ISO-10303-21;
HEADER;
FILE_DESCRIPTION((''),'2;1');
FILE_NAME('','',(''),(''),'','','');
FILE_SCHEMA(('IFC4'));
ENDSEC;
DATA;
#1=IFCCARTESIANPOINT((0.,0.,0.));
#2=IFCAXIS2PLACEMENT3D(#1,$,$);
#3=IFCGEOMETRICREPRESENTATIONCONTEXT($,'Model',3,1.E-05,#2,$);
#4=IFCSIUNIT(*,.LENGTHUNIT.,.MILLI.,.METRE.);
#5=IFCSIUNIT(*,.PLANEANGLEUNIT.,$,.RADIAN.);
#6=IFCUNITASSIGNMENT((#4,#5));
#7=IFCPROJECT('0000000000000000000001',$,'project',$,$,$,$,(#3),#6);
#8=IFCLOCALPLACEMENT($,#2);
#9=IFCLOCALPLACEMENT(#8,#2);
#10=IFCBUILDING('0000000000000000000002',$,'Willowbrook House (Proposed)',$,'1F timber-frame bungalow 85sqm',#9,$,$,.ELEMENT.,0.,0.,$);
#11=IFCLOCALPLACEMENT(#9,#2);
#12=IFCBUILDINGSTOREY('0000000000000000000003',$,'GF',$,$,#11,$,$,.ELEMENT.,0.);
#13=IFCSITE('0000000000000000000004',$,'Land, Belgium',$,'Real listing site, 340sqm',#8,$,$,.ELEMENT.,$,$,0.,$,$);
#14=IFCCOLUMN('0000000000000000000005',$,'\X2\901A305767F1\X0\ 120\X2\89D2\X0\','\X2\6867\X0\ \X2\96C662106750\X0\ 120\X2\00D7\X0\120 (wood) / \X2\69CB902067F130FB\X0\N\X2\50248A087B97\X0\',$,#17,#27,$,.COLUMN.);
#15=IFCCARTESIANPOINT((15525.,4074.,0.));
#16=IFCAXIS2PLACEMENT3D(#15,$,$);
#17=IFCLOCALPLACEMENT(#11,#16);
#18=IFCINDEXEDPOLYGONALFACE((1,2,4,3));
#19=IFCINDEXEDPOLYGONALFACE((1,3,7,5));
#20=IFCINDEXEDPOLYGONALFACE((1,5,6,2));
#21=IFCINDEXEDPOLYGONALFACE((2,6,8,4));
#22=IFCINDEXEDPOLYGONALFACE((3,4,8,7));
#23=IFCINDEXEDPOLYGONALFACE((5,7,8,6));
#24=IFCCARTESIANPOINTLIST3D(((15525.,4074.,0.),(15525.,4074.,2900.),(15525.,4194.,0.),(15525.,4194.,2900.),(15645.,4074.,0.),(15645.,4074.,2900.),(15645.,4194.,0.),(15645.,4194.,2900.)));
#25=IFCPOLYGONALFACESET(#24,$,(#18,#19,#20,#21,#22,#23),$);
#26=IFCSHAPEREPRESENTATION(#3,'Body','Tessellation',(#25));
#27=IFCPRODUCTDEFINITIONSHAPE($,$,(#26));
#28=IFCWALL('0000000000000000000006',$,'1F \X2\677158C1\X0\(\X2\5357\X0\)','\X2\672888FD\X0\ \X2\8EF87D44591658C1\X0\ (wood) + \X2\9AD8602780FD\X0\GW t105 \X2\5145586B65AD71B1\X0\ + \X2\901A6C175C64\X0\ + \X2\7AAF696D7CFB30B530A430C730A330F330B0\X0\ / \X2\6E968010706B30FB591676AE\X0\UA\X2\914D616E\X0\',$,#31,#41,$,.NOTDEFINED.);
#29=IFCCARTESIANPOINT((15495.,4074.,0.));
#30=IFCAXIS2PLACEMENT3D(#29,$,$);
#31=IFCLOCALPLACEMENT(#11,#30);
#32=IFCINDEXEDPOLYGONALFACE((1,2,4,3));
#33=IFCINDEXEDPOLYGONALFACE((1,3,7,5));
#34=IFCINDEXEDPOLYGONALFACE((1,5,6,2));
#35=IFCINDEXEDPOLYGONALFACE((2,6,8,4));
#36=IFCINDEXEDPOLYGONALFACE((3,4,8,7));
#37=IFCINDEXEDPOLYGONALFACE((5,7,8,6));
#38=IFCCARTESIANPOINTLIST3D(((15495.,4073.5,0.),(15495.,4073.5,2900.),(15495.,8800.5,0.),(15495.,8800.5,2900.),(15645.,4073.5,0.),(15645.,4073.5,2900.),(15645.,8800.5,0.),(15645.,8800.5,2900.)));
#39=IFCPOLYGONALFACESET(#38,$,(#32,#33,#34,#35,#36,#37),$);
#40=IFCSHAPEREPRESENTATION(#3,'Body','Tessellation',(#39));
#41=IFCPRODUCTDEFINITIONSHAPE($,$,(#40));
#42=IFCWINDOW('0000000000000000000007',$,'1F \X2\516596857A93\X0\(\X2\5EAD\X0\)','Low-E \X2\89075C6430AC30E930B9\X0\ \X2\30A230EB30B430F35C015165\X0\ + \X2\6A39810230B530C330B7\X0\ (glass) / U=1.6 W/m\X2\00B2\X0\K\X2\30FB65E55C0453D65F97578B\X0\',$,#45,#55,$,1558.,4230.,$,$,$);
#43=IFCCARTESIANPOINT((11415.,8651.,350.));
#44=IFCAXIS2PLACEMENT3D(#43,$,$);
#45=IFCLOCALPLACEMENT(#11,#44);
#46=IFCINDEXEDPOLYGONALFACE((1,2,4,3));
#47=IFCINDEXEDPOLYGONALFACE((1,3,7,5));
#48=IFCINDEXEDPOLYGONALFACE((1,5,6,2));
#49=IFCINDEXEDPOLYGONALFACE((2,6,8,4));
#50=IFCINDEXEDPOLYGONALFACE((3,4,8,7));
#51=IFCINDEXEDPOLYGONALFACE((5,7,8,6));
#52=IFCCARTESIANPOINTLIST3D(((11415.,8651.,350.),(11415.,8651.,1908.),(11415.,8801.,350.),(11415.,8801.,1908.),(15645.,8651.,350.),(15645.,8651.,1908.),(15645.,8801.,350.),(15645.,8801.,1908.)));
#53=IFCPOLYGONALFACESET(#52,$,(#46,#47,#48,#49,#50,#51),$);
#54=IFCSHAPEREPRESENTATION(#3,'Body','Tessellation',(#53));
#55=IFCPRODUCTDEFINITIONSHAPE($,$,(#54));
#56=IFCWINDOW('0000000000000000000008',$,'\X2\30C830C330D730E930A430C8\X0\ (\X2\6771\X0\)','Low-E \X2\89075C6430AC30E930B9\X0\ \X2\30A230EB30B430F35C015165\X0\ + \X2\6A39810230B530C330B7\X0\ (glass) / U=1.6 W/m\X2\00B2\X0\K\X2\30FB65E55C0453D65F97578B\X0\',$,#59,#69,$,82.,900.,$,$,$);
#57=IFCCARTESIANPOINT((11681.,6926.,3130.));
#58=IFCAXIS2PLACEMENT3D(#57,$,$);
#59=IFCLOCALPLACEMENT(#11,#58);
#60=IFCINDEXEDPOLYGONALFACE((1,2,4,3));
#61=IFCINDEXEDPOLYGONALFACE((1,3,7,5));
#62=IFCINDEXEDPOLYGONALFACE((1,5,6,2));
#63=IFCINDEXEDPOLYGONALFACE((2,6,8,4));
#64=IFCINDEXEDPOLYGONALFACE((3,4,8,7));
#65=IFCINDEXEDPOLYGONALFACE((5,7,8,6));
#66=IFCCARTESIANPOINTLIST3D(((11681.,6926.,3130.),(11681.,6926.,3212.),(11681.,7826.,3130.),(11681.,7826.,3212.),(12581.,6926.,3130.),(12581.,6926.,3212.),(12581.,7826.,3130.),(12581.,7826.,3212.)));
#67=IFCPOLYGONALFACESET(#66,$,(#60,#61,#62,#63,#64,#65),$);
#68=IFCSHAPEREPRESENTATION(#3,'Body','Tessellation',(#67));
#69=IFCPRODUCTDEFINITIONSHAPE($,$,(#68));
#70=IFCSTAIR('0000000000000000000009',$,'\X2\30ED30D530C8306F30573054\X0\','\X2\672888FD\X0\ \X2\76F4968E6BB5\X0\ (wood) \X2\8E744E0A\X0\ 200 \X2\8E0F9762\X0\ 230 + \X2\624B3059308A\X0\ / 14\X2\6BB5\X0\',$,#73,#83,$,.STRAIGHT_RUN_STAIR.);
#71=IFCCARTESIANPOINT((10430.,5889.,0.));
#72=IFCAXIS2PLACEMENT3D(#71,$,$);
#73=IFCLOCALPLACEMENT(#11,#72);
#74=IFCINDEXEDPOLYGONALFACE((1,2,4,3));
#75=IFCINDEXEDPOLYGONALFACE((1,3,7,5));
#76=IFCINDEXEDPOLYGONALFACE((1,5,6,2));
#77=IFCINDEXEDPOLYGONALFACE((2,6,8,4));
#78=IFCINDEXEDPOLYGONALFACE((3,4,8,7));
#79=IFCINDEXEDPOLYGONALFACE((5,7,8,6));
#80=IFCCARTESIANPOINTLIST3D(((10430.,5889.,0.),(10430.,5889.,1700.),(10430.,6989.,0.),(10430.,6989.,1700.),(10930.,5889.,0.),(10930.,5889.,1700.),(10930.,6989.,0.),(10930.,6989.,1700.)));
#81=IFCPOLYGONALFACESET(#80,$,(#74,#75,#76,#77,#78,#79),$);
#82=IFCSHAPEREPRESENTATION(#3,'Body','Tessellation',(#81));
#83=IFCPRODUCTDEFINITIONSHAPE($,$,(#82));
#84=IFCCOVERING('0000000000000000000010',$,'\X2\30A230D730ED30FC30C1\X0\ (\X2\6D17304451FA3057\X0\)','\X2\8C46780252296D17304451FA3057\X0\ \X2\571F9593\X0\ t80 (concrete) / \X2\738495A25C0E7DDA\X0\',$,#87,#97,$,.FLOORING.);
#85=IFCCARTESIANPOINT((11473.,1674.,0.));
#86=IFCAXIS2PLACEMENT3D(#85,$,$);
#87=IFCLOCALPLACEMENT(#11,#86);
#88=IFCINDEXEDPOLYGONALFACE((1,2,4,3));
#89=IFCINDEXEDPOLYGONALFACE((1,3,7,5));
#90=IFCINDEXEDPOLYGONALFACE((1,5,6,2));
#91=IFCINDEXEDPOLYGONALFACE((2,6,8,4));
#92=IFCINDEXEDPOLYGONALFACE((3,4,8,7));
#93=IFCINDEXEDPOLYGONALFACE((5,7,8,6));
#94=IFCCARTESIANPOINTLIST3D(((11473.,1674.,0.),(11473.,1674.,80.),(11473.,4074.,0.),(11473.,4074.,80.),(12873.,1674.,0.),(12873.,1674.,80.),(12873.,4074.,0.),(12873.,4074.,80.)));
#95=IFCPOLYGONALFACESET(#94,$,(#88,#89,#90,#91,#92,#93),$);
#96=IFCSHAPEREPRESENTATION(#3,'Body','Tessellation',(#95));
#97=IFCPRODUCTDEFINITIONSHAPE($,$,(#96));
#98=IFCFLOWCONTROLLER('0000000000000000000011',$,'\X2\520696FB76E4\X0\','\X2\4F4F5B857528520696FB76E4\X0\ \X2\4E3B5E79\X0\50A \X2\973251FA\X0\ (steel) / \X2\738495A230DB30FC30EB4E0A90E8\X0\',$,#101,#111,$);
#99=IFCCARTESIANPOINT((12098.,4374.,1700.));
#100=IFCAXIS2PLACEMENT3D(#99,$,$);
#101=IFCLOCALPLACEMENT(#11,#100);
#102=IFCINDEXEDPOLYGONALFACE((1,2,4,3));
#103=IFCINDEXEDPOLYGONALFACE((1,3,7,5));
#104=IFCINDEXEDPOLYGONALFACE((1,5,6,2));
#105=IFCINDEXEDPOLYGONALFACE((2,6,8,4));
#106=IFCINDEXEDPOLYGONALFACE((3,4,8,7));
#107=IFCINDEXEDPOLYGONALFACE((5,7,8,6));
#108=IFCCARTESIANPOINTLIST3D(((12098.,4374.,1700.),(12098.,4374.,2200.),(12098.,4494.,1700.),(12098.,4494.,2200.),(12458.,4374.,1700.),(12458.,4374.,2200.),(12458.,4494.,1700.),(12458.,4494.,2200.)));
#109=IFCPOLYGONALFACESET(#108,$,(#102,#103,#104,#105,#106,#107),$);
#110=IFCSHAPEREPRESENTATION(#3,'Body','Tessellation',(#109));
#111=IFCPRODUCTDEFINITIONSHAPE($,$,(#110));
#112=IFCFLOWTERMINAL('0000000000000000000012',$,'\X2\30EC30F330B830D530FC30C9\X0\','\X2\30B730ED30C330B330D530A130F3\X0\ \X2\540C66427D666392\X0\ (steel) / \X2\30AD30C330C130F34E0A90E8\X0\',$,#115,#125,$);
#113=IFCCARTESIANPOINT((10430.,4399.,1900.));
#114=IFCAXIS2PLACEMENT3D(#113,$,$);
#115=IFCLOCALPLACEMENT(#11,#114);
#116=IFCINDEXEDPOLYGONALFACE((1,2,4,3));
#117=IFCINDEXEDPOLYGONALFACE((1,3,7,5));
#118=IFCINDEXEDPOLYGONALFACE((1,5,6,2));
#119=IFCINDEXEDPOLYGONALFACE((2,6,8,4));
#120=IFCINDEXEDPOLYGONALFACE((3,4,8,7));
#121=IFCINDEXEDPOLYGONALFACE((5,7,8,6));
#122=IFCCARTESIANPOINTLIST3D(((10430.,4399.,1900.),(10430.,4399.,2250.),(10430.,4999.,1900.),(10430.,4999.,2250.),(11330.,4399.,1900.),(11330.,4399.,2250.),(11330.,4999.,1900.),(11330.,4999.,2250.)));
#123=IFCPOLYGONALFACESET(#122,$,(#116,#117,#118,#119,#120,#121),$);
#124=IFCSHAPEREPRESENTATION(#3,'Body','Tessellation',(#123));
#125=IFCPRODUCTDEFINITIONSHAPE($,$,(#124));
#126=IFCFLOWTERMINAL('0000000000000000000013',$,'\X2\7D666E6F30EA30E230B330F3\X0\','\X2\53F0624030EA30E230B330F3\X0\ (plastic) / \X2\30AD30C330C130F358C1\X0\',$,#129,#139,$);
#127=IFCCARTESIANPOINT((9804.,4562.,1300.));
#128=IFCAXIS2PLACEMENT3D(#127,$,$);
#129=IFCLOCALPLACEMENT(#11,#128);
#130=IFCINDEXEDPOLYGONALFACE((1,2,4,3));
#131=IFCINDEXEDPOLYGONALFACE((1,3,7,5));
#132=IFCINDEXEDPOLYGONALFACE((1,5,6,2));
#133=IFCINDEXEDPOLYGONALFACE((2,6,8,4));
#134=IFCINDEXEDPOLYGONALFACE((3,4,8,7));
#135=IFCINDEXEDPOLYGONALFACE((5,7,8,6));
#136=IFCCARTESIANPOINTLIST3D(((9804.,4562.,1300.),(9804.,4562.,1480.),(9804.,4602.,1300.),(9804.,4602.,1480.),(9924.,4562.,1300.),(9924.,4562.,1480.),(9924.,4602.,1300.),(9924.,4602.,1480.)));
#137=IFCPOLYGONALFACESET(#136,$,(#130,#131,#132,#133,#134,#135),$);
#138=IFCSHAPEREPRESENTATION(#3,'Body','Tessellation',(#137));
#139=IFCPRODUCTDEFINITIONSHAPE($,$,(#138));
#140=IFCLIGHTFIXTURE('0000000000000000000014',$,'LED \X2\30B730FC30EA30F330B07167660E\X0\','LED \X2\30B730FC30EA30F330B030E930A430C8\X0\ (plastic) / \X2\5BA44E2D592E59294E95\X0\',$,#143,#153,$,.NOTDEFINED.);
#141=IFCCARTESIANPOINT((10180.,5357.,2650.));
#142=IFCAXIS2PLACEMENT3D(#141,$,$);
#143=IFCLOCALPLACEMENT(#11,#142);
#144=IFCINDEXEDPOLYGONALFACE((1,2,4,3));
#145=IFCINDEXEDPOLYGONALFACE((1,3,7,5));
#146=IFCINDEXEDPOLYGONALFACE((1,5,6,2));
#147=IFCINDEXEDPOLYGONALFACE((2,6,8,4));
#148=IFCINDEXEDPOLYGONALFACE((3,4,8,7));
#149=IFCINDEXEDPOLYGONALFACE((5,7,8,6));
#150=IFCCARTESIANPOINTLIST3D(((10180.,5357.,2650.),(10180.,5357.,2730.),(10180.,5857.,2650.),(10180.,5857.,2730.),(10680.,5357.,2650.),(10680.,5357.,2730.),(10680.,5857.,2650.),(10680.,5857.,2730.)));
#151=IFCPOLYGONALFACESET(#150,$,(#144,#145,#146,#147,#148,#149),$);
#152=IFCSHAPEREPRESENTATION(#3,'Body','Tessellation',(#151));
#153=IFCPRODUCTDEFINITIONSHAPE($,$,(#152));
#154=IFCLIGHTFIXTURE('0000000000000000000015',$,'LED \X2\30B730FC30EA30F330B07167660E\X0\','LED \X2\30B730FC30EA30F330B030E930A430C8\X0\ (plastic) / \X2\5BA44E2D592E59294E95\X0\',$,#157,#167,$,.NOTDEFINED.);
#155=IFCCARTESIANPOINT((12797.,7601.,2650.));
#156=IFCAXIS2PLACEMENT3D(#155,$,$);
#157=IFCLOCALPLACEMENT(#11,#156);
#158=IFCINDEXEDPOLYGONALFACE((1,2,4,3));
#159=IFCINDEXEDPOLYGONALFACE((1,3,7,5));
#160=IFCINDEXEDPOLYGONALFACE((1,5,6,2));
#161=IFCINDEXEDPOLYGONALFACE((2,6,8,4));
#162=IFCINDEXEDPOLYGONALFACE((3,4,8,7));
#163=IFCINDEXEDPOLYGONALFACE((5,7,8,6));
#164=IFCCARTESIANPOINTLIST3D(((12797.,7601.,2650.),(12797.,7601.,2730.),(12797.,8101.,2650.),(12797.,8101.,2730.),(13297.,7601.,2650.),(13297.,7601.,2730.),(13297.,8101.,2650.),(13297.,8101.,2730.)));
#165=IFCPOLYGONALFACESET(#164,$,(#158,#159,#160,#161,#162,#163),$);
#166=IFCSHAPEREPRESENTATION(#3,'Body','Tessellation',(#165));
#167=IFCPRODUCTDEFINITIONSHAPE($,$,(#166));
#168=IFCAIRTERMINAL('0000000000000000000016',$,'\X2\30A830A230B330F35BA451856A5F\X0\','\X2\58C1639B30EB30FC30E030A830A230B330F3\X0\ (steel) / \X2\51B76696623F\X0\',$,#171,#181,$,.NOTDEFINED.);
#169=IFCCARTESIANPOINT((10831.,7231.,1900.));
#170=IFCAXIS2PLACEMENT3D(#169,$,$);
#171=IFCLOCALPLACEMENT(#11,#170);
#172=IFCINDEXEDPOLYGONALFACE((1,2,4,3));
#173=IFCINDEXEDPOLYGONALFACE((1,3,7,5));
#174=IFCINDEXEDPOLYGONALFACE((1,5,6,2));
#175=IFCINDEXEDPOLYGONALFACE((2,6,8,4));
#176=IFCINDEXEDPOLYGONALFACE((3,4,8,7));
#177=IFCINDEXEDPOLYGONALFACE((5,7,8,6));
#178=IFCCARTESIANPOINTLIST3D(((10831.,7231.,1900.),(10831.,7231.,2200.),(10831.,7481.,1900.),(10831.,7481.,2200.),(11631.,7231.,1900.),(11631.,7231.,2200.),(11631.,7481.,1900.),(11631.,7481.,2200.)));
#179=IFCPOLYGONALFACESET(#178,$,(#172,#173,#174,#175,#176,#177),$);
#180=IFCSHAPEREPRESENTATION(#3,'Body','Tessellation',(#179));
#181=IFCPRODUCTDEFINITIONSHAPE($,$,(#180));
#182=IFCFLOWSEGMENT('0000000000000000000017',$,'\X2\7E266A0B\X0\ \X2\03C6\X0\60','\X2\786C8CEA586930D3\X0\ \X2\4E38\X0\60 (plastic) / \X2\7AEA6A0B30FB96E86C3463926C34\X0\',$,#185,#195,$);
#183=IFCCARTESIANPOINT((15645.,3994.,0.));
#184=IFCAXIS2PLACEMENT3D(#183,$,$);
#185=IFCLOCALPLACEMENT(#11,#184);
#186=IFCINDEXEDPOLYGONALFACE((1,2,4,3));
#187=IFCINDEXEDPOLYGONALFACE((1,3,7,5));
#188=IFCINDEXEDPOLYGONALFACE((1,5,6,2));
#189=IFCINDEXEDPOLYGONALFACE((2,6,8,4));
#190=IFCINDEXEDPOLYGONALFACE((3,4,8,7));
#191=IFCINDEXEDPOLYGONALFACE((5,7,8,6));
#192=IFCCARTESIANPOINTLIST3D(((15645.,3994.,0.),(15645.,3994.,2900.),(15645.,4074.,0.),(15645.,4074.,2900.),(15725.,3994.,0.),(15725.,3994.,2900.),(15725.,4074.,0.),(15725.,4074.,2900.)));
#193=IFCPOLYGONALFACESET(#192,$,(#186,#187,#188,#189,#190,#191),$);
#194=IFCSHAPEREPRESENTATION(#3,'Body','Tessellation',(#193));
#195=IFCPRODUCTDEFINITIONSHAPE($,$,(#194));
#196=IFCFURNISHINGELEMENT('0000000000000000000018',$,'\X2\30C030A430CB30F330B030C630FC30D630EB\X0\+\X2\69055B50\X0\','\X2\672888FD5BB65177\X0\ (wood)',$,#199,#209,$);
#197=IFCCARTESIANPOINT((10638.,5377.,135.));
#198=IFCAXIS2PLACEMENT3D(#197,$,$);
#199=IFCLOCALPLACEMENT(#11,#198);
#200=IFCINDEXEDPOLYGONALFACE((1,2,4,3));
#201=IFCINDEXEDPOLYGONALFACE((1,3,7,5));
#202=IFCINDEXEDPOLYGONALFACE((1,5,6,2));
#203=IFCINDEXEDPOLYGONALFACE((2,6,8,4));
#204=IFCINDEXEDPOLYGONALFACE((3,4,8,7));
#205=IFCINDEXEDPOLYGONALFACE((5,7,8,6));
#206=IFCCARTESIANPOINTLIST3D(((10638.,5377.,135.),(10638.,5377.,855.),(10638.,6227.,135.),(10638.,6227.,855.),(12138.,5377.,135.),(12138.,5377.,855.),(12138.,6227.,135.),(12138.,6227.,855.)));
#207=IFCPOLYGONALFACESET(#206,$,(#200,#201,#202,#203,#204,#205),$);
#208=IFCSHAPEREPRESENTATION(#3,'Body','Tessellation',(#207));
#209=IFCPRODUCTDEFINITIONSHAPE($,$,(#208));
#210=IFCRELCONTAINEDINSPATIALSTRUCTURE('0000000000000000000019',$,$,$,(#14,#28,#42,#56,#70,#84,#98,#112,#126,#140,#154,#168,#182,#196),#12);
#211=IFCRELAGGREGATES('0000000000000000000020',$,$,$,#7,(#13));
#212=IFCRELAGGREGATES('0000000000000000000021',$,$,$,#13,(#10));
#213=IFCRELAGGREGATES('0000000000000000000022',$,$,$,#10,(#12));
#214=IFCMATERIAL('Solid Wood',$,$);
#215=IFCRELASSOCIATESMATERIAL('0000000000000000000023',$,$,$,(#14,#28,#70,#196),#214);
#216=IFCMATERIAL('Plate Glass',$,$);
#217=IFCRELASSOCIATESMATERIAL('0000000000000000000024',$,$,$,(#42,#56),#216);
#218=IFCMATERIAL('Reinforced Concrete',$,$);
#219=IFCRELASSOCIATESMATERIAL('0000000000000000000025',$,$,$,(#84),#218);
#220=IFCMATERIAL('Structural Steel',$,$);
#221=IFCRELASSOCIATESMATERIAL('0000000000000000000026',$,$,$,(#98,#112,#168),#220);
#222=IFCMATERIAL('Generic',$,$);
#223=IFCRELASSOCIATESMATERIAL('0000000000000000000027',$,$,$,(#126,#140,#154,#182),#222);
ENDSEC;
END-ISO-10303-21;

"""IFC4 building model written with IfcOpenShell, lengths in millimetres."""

from ifc_helpers import new_model, si_unit, frame, frame_2d, origin, place, context, project, spatial, rectangle, extrude, material, element, fill, save


model = new_model("IFC4")

# Units and contexts
model_context = context("Model", 3, precision=1e-05, world=origin())
ifc_project = project(units=[si_unit("LENGTHUNIT", "METRE", prefix="MILLI"), si_unit("PLANEANGLEUNIT", "RADIAN")], contexts=[model_context])

# Site, building, storey
site_placement = place(None, origin())
site = spatial("IfcSite", under=ifc_project, at=site_placement, Name="Land, Belgium", ObjectType="Real listing site, 340sqm", CompositionType="ELEMENT", RefElevation=0.0)
building_placement = place(site_placement, origin())
building = spatial("IfcBuilding", under=site, at=building_placement, Name="Willowbrook House (Proposed)", ObjectType="1F timber-frame bungalow 85sqm", CompositionType="ELEMENT", ElevationOfRefHeight=0.0, ElevationOfTerrain=0.0)
storey_placement = place(building_placement, origin())
storey = spatial("IfcBuildingStorey", under=building, at=storey_placement, Name="GF", CompositionType="ELEMENT", Elevation=0.0)

# Column
ifc_material_1 = material(Name="Solid Wood")
column_1_placement = place(storey_placement, frame((15525.0, 4074.0, 0.0)))
element("IfcColumn", 1, at=column_1_placement, inside=storey, material=ifc_material_1, Name="通し柱 120角", Description="桧 集成材 120×120 (wood) / 構造柱・N値計算", PredefinedType="COLUMN", context=model_context, shape_type="SweptSolid", body=[
    extrude(rectangle(XDim=120.0, YDim=120.0, at=frame_2d((60.0, 60.0))), frame((15525.0, 4074.0, 0.0)), (0.0, 0.0, 1.0), 2900.0),
])

# Wall, opening, window
wall_1_placement = place(storey_placement, frame((15495.0, 4074.0, 0.0)))
wall_1 = element("IfcWall", 2, at=wall_1_placement, inside=storey, material=ifc_material_1, Name="1F 東壁(南)", Description="木製 軸組外壁 (wood) + 高性能GW t105 充填断熱 + 通気層 + 窯業系サイディング / 準耐火・外皮UA配慮", PredefinedType="NOTDEFINED", context=model_context, shape_type="SweptSolid", body=[
    extrude(rectangle(XDim=150.0, YDim=4727.0, at=frame_2d((75.0, 2363.0))), frame((15495.0, 4074.0, 0.0)), (0.0, 0.0, 1.0), 2900.0),
])
opening_1_placement = place(storey_placement, frame((11415.0, 8651.0, 350.0)))
opening_1 = element("IfcOpeningElement", 3, at=opening_1_placement, cuts=wall_1, PredefinedType="NOTDEFINED", context=model_context, shape_type="SweptSolid", body=[
    extrude(rectangle(XDim=4230.0, YDim=150.0, at=frame_2d((2115.0, 75.0))), frame((11415.0, 8651.0, 350.0)), (0.0, 0.0, 1.0), 1558.0),
])
ifc_material_2 = material(Name="Plate Glass")
window_1_placement = place(storey_placement, frame((11415.0, 8651.0, 350.0)))
window_1 = element("IfcWindow", 4, at=window_1_placement, inside=storey, material=ifc_material_2, Name="1F 入隅窓(庭)", Description="Low-E 複層ガラス アルゴン封入 + 樹脂サッシ (glass) / U=1.6 W/m²K・日射取得型", OverallHeight=1558.0, OverallWidth=4230.0, context=model_context, shape_type="SweptSolid", body=[
    extrude(rectangle(XDim=4230.0, YDim=150.0, at=frame_2d((2115.0, 75.0))), frame((11415.0, 8651.0, 350.0)), (0.0, 0.0, 1.0), 1558.0),
])
fill(opening_1, window_1)

# Window
window_2_placement = place(storey_placement, frame((11681.0, 6926.0, 3130.0)))
element("IfcWindow", 5, at=window_2_placement, inside=storey, material=ifc_material_2, Name="トップライト (東)", Description="Low-E 複層ガラス アルゴン封入 + 樹脂サッシ (glass) / U=1.6 W/m²K・日射取得型", OverallHeight=82.0, OverallWidth=900.0, context=model_context, shape_type="SweptSolid", body=[
    extrude(rectangle(XDim=900.0, YDim=900.0, at=frame_2d((450.0, 450.0))), frame((11681.0, 6926.0, 3130.0)), (0.0, 0.0, 1.0), 82.0),
])

# Stair
stair_placement = place(storey_placement, frame((10430.0, 5889.0, 0.0)))
element("IfcStair", 6, at=stair_placement, inside=storey, material=ifc_material_1, Name="ロフトはしご", Description="木製 直階段 (wood) 蹴上 200 踏面 230 + 手すり / 14段", PredefinedType="STRAIGHT_RUN_STAIR", context=model_context, shape_type="SweptSolid", body=[
    extrude(rectangle(XDim=500.0, YDim=1100.0, at=frame_2d((250.0, 550.0))), frame((10430.0, 5889.0, 0.0)), (0.0, 0.0, 1.0), 1700.0),
])

# Covering
ifc_material_3 = material(Name="Reinforced Concrete")
covering_placement = place(storey_placement, frame((11473.0, 1674.0, 0.0)))
element("IfcCovering", 7, at=covering_placement, inside=storey, material=ifc_material_3, Name="アプローチ (洗い出し)", Description="豆砂利洗い出し 土間 t80 (concrete) / 玄関導線", PredefinedType="FLOORING", context=model_context, shape_type="SweptSolid", body=[
    extrude(rectangle(XDim=1400.0, YDim=2400.0, at=frame_2d((700.0, 1200.0))), frame((11473.0, 1674.0, 0.0)), (0.0, 0.0, 1.0), 80.0),
])

# Flow controller
ifc_material_4 = material(Name="Structural Steel")
flow_controller_placement = place(storey_placement, frame((12098.0, 4374.0, 1700.0)))
element("IfcFlowController", 8, at=flow_controller_placement, inside=storey, material=ifc_material_4, Name="分電盤", Description="住宅用分電盤 主幹50A 露出 (steel) / 玄関ホール上部", context=model_context, shape_type="SweptSolid", body=[
    extrude(rectangle(XDim=360.0, YDim=120.0, at=frame_2d((180.0, 60.0))), frame((12098.0, 4374.0, 1700.0)), (0.0, 0.0, 1.0), 500.0),
])

# Flow terminals
flow_terminal_1_placement = place(storey_placement, frame((10430.0, 4399.0, 1900.0)))
element("IfcFlowTerminal", 9, at=flow_terminal_1_placement, inside=storey, material=ifc_material_4, Name="レンジフード", Description="シロッコファン 同時給排 (steel) / キッチン上部", context=model_context, shape_type="SweptSolid", body=[
    extrude(rectangle(XDim=900.0, YDim=600.0, at=frame_2d((450.0, 300.0))), frame((10430.0, 4399.0, 1900.0)), (0.0, 0.0, 1.0), 350.0),
])
ifc_material_5 = material(Name="Generic")
flow_terminal_2_placement = place(storey_placement, frame((9804.0, 4562.0, 1300.0)))
element("IfcFlowTerminal", 10, at=flow_terminal_2_placement, inside=storey, material=ifc_material_5, Name="給湯リモコン", Description="台所リモコン (plastic) / キッチン壁", context=model_context, shape_type="SweptSolid", body=[
    extrude(rectangle(XDim=120.0, YDim=40.0, at=frame_2d((60.0, 20.0))), frame((9804.0, 4562.0, 1300.0)), (0.0, 0.0, 1.0), 180.0),
])

# Light fixtures
light_fixture_1_placement = place(storey_placement, frame((10180.0, 5357.0, 2650.0)))
element("IfcLightFixture", 11, at=light_fixture_1_placement, inside=storey, material=ifc_material_5, Name="LED シーリング照明", Description="LED シーリングライト (plastic) / 室中央天井", PredefinedType="NOTDEFINED", context=model_context, shape_type="SweptSolid", body=[
    extrude(rectangle(XDim=500.0, YDim=500.0, at=frame_2d((250.0, 250.0))), frame((10180.0, 5357.0, 2650.0)), (0.0, 0.0, 1.0), 80.0),
])
light_fixture_2_placement = place(storey_placement, frame((12797.0, 7601.0, 2650.0)))
element("IfcLightFixture", 12, at=light_fixture_2_placement, inside=storey, material=ifc_material_5, Name="LED シーリング照明", Description="LED シーリングライト (plastic) / 室中央天井", PredefinedType="NOTDEFINED", context=model_context, shape_type="SweptSolid", body=[
    extrude(rectangle(XDim=500.0, YDim=500.0, at=frame_2d((250.0, 250.0))), frame((12797.0, 7601.0, 2650.0)), (0.0, 0.0, 1.0), 80.0),
])

# Air terminal
air_terminal_placement = place(storey_placement, frame((10831.0, 7231.0, 1900.0)))
element("IfcAirTerminal", 13, at=air_terminal_placement, inside=storey, material=ifc_material_4, Name="エアコン室内機", Description="壁掛ルームエアコン (steel) / 冷暖房", PredefinedType="NOTDEFINED", context=model_context, shape_type="SweptSolid", body=[
    extrude(rectangle(XDim=800.0, YDim=250.0, at=frame_2d((400.0, 125.0))), frame((10831.0, 7231.0, 1900.0)), (0.0, 0.0, 1.0), 300.0),
])

# Flow segment
flow_segment_placement = place(storey_placement, frame((15645.0, 3994.0, 0.0)))
element("IfcFlowSegment", 14, at=flow_segment_placement, inside=storey, material=ifc_material_5, Name="縦樋 φ60", Description="硬質塩ビ 丸60 (plastic) / 竪樋・雨水排水", context=model_context, shape_type="SweptSolid", body=[
    extrude(rectangle(XDim=80.0, YDim=80.0, at=frame_2d((40.0, 40.0))), frame((15645.0, 3994.0, 0.0)), (0.0, 0.0, 1.0), 2900.0),
])

# Furnishing element
furnishing_1_placement = place(storey_placement, frame((10638.0, 5377.0, 135.0)))
element("IfcFurnishingElement", 15, at=furnishing_1_placement, inside=storey, material=ifc_material_1, Name="ダイニングテーブル+椅子", Description="木製家具 (wood)", context=model_context, shape_type="SweptSolid", body=[
    extrude(rectangle(XDim=1500.0, YDim=850.0, at=frame_2d((750.0, 425.0))), frame((10638.0, 5377.0, 135.0)), (0.0, 0.0, 1.0), 720.0),
])

save(model, "model.ifc")
